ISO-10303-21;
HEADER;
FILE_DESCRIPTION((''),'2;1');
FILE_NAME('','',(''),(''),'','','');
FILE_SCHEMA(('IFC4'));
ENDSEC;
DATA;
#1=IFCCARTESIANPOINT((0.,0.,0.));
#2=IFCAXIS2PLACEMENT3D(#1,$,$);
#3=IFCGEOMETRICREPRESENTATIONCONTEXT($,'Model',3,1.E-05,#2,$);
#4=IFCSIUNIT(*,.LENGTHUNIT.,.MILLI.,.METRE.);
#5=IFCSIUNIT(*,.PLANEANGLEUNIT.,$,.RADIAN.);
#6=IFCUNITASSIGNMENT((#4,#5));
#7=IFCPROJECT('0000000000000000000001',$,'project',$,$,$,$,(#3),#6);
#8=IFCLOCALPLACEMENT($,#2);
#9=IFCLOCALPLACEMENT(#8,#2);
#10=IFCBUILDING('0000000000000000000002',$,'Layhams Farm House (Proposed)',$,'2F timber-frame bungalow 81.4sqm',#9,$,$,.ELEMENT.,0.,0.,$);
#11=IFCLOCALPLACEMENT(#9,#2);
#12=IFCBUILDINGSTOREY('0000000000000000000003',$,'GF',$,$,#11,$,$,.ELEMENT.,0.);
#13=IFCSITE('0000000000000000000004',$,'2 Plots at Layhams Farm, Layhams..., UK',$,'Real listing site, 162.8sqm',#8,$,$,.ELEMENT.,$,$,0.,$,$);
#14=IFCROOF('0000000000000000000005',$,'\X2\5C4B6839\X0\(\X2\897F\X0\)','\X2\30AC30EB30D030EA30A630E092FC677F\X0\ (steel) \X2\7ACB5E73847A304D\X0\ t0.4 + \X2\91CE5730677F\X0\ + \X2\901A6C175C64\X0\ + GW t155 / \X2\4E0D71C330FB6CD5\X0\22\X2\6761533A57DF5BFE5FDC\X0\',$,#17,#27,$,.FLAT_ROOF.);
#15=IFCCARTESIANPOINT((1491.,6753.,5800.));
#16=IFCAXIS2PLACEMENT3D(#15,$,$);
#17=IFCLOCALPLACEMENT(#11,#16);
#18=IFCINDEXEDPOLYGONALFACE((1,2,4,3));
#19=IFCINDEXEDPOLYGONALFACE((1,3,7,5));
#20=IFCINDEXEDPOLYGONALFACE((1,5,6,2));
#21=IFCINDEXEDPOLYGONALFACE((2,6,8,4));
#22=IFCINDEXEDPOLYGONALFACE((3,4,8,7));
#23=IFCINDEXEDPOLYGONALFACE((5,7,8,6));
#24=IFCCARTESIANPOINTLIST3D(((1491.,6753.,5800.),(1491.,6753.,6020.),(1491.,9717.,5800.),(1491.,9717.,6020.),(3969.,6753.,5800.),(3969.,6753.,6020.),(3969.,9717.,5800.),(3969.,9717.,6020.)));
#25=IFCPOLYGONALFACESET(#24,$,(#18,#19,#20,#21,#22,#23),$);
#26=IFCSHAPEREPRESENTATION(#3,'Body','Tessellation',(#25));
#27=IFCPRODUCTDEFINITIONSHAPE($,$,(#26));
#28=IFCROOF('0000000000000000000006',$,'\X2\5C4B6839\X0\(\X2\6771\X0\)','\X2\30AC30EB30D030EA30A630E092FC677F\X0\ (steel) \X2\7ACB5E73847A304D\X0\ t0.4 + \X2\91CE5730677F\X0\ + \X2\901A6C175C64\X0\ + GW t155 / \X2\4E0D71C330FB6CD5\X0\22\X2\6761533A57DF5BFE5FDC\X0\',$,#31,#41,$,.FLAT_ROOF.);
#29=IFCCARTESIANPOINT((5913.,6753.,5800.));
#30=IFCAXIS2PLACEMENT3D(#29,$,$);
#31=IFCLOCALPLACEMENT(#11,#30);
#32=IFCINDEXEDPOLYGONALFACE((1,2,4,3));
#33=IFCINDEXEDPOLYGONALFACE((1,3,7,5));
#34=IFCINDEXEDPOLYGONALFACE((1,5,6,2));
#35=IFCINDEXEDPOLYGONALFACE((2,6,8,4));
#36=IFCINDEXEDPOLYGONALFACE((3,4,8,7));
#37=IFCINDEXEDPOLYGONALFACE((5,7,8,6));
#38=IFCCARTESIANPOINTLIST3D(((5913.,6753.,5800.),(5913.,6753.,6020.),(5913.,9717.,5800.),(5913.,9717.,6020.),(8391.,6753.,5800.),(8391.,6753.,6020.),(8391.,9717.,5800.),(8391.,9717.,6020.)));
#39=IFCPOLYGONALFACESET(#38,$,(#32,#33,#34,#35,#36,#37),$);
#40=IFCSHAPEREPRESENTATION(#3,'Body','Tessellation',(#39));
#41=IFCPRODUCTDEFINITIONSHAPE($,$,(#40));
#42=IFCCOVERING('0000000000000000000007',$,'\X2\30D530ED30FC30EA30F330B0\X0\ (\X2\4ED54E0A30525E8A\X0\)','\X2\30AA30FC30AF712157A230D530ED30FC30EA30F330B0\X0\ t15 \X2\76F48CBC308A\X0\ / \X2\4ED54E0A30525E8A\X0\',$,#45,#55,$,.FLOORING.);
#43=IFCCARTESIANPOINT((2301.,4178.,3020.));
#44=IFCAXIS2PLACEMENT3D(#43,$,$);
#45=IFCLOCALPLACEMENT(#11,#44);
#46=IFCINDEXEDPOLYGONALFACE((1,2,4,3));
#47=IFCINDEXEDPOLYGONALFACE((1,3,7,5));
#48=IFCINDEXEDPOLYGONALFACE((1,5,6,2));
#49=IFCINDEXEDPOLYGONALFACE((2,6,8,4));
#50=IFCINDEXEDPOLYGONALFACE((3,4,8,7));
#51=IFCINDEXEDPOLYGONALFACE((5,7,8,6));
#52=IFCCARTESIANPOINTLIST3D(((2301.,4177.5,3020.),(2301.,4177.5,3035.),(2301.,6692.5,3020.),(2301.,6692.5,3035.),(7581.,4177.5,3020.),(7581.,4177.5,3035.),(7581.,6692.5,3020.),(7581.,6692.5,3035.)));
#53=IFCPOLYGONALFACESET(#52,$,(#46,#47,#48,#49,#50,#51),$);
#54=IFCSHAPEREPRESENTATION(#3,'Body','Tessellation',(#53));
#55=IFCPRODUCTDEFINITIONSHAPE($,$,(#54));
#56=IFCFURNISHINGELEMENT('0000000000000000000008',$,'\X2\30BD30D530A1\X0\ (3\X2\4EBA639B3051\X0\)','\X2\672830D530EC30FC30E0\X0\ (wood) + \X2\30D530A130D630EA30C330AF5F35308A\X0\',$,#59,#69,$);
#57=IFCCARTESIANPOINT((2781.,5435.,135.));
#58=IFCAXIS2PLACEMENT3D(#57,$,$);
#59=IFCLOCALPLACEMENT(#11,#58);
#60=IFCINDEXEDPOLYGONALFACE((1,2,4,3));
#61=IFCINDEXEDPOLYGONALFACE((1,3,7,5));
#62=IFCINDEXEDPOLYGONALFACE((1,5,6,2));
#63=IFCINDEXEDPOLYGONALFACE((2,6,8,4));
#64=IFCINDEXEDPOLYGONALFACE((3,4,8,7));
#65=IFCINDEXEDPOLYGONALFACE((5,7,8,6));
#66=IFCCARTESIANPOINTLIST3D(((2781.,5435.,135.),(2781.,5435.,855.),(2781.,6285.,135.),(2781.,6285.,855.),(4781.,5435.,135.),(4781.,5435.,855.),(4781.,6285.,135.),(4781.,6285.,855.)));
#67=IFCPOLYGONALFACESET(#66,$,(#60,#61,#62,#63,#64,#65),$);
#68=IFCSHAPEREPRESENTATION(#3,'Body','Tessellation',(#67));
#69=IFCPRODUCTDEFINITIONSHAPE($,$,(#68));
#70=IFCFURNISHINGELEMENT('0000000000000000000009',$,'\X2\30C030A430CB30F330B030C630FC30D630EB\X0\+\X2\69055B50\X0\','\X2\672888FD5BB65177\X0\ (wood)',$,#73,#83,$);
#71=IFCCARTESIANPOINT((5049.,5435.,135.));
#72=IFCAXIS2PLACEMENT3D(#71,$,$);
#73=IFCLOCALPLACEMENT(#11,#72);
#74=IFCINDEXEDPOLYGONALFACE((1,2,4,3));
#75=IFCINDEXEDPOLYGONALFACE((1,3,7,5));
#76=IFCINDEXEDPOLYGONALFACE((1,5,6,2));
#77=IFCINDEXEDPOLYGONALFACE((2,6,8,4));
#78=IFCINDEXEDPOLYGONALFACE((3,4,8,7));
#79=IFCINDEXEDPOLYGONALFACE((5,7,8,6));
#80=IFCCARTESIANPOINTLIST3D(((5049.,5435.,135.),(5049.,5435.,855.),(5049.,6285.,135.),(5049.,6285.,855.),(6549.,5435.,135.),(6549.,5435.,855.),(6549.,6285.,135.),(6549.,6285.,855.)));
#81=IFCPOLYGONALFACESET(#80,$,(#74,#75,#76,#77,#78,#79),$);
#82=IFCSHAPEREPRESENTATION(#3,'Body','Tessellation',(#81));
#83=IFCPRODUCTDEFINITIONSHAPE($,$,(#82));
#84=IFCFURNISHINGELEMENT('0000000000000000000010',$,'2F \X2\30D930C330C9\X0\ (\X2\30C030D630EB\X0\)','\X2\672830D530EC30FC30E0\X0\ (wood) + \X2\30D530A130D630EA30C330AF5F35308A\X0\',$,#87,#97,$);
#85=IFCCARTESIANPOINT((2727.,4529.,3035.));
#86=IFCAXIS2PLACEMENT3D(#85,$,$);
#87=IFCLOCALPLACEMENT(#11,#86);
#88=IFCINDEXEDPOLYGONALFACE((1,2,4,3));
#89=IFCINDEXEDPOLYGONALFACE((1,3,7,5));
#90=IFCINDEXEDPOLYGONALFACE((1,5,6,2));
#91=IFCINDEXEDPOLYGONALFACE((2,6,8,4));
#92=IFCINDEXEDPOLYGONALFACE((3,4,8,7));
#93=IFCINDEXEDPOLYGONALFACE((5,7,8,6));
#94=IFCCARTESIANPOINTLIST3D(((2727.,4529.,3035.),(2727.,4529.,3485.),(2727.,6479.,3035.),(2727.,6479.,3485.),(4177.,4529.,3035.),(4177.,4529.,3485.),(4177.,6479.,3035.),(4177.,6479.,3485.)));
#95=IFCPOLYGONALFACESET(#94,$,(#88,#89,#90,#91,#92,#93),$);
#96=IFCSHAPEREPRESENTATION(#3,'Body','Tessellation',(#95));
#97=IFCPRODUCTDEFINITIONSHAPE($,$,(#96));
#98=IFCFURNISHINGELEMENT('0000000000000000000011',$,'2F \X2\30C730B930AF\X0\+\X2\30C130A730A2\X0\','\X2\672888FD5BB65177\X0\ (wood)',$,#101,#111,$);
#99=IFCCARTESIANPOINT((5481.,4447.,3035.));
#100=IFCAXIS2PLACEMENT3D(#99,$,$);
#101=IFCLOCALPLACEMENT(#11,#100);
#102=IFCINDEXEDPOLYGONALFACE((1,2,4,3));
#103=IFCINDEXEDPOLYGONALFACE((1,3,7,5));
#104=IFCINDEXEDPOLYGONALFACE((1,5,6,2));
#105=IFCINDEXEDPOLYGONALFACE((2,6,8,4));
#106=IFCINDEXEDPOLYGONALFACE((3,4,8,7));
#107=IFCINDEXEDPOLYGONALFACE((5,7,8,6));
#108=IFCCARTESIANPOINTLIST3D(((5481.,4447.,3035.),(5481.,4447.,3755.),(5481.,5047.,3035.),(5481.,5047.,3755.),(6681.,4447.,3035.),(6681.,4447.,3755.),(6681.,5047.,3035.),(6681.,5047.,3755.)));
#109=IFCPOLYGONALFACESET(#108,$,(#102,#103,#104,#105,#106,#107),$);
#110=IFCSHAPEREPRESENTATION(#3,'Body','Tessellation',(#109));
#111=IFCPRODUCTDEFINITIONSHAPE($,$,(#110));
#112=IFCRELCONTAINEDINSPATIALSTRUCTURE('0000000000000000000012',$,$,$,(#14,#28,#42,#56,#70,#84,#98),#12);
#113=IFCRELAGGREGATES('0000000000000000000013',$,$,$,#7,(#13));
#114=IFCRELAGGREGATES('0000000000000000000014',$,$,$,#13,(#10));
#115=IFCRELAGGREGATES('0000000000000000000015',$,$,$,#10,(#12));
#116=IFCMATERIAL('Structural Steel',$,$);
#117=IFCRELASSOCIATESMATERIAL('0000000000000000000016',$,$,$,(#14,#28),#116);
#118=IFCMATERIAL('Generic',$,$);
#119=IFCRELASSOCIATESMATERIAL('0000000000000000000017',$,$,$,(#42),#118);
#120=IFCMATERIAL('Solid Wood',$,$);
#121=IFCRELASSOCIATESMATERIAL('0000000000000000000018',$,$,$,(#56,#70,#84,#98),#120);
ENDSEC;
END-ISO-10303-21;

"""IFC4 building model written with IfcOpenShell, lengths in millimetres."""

from ifc_helpers import new_model, si_unit, frame, frame_2d, origin, place, context, project, spatial, rectangle, extrude, material, element, save


model = new_model("IFC4")

# Units and contexts
model_context = context("Model", 3, precision=1e-05, world=origin())
ifc_project = project(units=[si_unit("LENGTHUNIT", "METRE", prefix="MILLI"), si_unit("PLANEANGLEUNIT", "RADIAN")], contexts=[model_context])

# Site, building, storey
site_placement = place(None, origin())
site = spatial("IfcSite", under=ifc_project, at=site_placement, Name="2 Plots at Layhams Farm, Layhams..., UK", ObjectType="Real listing site, 162.8sqm", CompositionType="ELEMENT", RefElevation=0.0)
building_placement = place(site_placement, origin())
building = spatial("IfcBuilding", under=site, at=building_placement, Name="Layhams Farm House (Proposed)", ObjectType="2F timber-frame bungalow 81.4sqm", CompositionType="ELEMENT", ElevationOfRefHeight=0.0, ElevationOfTerrain=0.0)
storey_placement = place(building_placement, origin())
storey = spatial("IfcBuildingStorey", under=building, at=storey_placement, Name="GF", CompositionType="ELEMENT", Elevation=0.0)

# Shared definitions
ifc_material_1 = material(Name="Solid Wood")

# Roofs
ifc_material_2 = material(Name="Structural Steel")
roof_1_placement = place(storey_placement, frame((1491.0, 6753.0, 5800.0)))
element("IfcRoof", 1, at=roof_1_placement, inside=storey, material=ifc_material_2, Name="屋根(西)", Description="ガルバリウム鋼板 (steel) 立平葺き t0.4 + 野地板 + 通気層 + GW t155 / 不燃・法22条区域対応", PredefinedType="FLAT_ROOF", context=model_context, shape_type="SweptSolid", body=[
    extrude(rectangle(XDim=2478.0, YDim=2964.0, at=frame_2d((1239.0, 1482.0))), frame((1491.0, 6753.0, 5800.0)), (0.0, 0.0, 1.0), 220.0),
])
roof_2_placement = place(storey_placement, frame((5913.0, 6753.0, 5800.0)))
element("IfcRoof", 2, at=roof_2_placement, inside=storey, material=ifc_material_2, Name="屋根(東)", Description="ガルバリウム鋼板 (steel) 立平葺き t0.4 + 野地板 + 通気層 + GW t155 / 不燃・法22条区域対応", PredefinedType="FLAT_ROOF", context=model_context, shape_type="SweptSolid", body=[
    extrude(rectangle(XDim=2478.0, YDim=2964.0, at=frame_2d((1239.0, 1482.0))), frame((5913.0, 6753.0, 5800.0)), (0.0, 0.0, 1.0), 220.0),
])

# Covering
ifc_material_3 = material(Name="Generic")
covering_placement = place(storey_placement, frame((2301.0, 4178.0, 3020.0)))
element("IfcCovering", 3, at=covering_placement, inside=storey, material=ifc_material_3, Name="フローリング (仕上げ床)", Description="オーク無垢フローリング t15 直貼り / 仕上げ床", PredefinedType="FLOORING", context=model_context, shape_type="SweptSolid", body=[
    extrude(rectangle(XDim=5280.0, YDim=2515.0, at=frame_2d((2640.0, 1257.0))), frame((2301.0, 4178.0, 3020.0)), (0.0, 0.0, 1.0), 15.0),
])

# Furnishing elements
furnishing_1_placement = place(storey_placement, frame((2781.0, 5435.0, 135.0)))
element("IfcFurnishingElement", 4, at=furnishing_1_placement, inside=storey, material=ifc_material_1, Name="ソファ (3人掛け)", Description="木フレーム (wood) + ファブリック張り", context=model_context, shape_type="SweptSolid", body=[
    extrude(rectangle(XDim=2000.0, YDim=850.0, at=frame_2d((1000.0, 425.0))), frame((2781.0, 5435.0, 135.0)), (0.0, 0.0, 1.0), 720.0),
])
furnishing_2_placement = place(storey_placement, frame((5049.0, 5435.0, 135.0)))
element("IfcFurnishingElement", 5, at=furnishing_2_placement, inside=storey, material=ifc_material_1, Name="ダイニングテーブル+椅子", Description="木製家具 (wood)", context=model_context, shape_type="SweptSolid", body=[
    extrude(rectangle(XDim=1500.0, YDim=850.0, at=frame_2d((750.0, 425.0))), frame((5049.0, 5435.0, 135.0)), (0.0, 0.0, 1.0), 720.0),
])
furnishing_3_placement = place(storey_placement, frame((2727.0, 4529.0, 3035.0)))
element("IfcFurnishingElement", 6, at=furnishing_3_placement, inside=storey, material=ifc_material_1, Name="2F ベッド (ダブル)", Description="木フレーム (wood) + ファブリック張り", context=model_context, shape_type="SweptSolid", body=[
    extrude(rectangle(XDim=1450.0, YDim=1950.0, at=frame_2d((725.0, 975.0))), frame((2727.0, 4529.0, 3035.0)), (0.0, 0.0, 1.0), 450.0),
])
furnishing_4_placement = place(storey_placement, frame((5481.0, 4447.0, 3035.0)))
element("IfcFurnishingElement", 7, at=furnishing_4_placement, inside=storey, material=ifc_material_1, Name="2F デスク+チェア", Description="木製家具 (wood)", context=model_context, shape_type="SweptSolid", body=[
    extrude(rectangle(XDim=1200.0, YDim=600.0, at=frame_2d((600.0, 300.0))), frame((5481.0, 4447.0, 3035.0)), (0.0, 0.0, 1.0), 720.0),
])

save(model, "model.ifc")
